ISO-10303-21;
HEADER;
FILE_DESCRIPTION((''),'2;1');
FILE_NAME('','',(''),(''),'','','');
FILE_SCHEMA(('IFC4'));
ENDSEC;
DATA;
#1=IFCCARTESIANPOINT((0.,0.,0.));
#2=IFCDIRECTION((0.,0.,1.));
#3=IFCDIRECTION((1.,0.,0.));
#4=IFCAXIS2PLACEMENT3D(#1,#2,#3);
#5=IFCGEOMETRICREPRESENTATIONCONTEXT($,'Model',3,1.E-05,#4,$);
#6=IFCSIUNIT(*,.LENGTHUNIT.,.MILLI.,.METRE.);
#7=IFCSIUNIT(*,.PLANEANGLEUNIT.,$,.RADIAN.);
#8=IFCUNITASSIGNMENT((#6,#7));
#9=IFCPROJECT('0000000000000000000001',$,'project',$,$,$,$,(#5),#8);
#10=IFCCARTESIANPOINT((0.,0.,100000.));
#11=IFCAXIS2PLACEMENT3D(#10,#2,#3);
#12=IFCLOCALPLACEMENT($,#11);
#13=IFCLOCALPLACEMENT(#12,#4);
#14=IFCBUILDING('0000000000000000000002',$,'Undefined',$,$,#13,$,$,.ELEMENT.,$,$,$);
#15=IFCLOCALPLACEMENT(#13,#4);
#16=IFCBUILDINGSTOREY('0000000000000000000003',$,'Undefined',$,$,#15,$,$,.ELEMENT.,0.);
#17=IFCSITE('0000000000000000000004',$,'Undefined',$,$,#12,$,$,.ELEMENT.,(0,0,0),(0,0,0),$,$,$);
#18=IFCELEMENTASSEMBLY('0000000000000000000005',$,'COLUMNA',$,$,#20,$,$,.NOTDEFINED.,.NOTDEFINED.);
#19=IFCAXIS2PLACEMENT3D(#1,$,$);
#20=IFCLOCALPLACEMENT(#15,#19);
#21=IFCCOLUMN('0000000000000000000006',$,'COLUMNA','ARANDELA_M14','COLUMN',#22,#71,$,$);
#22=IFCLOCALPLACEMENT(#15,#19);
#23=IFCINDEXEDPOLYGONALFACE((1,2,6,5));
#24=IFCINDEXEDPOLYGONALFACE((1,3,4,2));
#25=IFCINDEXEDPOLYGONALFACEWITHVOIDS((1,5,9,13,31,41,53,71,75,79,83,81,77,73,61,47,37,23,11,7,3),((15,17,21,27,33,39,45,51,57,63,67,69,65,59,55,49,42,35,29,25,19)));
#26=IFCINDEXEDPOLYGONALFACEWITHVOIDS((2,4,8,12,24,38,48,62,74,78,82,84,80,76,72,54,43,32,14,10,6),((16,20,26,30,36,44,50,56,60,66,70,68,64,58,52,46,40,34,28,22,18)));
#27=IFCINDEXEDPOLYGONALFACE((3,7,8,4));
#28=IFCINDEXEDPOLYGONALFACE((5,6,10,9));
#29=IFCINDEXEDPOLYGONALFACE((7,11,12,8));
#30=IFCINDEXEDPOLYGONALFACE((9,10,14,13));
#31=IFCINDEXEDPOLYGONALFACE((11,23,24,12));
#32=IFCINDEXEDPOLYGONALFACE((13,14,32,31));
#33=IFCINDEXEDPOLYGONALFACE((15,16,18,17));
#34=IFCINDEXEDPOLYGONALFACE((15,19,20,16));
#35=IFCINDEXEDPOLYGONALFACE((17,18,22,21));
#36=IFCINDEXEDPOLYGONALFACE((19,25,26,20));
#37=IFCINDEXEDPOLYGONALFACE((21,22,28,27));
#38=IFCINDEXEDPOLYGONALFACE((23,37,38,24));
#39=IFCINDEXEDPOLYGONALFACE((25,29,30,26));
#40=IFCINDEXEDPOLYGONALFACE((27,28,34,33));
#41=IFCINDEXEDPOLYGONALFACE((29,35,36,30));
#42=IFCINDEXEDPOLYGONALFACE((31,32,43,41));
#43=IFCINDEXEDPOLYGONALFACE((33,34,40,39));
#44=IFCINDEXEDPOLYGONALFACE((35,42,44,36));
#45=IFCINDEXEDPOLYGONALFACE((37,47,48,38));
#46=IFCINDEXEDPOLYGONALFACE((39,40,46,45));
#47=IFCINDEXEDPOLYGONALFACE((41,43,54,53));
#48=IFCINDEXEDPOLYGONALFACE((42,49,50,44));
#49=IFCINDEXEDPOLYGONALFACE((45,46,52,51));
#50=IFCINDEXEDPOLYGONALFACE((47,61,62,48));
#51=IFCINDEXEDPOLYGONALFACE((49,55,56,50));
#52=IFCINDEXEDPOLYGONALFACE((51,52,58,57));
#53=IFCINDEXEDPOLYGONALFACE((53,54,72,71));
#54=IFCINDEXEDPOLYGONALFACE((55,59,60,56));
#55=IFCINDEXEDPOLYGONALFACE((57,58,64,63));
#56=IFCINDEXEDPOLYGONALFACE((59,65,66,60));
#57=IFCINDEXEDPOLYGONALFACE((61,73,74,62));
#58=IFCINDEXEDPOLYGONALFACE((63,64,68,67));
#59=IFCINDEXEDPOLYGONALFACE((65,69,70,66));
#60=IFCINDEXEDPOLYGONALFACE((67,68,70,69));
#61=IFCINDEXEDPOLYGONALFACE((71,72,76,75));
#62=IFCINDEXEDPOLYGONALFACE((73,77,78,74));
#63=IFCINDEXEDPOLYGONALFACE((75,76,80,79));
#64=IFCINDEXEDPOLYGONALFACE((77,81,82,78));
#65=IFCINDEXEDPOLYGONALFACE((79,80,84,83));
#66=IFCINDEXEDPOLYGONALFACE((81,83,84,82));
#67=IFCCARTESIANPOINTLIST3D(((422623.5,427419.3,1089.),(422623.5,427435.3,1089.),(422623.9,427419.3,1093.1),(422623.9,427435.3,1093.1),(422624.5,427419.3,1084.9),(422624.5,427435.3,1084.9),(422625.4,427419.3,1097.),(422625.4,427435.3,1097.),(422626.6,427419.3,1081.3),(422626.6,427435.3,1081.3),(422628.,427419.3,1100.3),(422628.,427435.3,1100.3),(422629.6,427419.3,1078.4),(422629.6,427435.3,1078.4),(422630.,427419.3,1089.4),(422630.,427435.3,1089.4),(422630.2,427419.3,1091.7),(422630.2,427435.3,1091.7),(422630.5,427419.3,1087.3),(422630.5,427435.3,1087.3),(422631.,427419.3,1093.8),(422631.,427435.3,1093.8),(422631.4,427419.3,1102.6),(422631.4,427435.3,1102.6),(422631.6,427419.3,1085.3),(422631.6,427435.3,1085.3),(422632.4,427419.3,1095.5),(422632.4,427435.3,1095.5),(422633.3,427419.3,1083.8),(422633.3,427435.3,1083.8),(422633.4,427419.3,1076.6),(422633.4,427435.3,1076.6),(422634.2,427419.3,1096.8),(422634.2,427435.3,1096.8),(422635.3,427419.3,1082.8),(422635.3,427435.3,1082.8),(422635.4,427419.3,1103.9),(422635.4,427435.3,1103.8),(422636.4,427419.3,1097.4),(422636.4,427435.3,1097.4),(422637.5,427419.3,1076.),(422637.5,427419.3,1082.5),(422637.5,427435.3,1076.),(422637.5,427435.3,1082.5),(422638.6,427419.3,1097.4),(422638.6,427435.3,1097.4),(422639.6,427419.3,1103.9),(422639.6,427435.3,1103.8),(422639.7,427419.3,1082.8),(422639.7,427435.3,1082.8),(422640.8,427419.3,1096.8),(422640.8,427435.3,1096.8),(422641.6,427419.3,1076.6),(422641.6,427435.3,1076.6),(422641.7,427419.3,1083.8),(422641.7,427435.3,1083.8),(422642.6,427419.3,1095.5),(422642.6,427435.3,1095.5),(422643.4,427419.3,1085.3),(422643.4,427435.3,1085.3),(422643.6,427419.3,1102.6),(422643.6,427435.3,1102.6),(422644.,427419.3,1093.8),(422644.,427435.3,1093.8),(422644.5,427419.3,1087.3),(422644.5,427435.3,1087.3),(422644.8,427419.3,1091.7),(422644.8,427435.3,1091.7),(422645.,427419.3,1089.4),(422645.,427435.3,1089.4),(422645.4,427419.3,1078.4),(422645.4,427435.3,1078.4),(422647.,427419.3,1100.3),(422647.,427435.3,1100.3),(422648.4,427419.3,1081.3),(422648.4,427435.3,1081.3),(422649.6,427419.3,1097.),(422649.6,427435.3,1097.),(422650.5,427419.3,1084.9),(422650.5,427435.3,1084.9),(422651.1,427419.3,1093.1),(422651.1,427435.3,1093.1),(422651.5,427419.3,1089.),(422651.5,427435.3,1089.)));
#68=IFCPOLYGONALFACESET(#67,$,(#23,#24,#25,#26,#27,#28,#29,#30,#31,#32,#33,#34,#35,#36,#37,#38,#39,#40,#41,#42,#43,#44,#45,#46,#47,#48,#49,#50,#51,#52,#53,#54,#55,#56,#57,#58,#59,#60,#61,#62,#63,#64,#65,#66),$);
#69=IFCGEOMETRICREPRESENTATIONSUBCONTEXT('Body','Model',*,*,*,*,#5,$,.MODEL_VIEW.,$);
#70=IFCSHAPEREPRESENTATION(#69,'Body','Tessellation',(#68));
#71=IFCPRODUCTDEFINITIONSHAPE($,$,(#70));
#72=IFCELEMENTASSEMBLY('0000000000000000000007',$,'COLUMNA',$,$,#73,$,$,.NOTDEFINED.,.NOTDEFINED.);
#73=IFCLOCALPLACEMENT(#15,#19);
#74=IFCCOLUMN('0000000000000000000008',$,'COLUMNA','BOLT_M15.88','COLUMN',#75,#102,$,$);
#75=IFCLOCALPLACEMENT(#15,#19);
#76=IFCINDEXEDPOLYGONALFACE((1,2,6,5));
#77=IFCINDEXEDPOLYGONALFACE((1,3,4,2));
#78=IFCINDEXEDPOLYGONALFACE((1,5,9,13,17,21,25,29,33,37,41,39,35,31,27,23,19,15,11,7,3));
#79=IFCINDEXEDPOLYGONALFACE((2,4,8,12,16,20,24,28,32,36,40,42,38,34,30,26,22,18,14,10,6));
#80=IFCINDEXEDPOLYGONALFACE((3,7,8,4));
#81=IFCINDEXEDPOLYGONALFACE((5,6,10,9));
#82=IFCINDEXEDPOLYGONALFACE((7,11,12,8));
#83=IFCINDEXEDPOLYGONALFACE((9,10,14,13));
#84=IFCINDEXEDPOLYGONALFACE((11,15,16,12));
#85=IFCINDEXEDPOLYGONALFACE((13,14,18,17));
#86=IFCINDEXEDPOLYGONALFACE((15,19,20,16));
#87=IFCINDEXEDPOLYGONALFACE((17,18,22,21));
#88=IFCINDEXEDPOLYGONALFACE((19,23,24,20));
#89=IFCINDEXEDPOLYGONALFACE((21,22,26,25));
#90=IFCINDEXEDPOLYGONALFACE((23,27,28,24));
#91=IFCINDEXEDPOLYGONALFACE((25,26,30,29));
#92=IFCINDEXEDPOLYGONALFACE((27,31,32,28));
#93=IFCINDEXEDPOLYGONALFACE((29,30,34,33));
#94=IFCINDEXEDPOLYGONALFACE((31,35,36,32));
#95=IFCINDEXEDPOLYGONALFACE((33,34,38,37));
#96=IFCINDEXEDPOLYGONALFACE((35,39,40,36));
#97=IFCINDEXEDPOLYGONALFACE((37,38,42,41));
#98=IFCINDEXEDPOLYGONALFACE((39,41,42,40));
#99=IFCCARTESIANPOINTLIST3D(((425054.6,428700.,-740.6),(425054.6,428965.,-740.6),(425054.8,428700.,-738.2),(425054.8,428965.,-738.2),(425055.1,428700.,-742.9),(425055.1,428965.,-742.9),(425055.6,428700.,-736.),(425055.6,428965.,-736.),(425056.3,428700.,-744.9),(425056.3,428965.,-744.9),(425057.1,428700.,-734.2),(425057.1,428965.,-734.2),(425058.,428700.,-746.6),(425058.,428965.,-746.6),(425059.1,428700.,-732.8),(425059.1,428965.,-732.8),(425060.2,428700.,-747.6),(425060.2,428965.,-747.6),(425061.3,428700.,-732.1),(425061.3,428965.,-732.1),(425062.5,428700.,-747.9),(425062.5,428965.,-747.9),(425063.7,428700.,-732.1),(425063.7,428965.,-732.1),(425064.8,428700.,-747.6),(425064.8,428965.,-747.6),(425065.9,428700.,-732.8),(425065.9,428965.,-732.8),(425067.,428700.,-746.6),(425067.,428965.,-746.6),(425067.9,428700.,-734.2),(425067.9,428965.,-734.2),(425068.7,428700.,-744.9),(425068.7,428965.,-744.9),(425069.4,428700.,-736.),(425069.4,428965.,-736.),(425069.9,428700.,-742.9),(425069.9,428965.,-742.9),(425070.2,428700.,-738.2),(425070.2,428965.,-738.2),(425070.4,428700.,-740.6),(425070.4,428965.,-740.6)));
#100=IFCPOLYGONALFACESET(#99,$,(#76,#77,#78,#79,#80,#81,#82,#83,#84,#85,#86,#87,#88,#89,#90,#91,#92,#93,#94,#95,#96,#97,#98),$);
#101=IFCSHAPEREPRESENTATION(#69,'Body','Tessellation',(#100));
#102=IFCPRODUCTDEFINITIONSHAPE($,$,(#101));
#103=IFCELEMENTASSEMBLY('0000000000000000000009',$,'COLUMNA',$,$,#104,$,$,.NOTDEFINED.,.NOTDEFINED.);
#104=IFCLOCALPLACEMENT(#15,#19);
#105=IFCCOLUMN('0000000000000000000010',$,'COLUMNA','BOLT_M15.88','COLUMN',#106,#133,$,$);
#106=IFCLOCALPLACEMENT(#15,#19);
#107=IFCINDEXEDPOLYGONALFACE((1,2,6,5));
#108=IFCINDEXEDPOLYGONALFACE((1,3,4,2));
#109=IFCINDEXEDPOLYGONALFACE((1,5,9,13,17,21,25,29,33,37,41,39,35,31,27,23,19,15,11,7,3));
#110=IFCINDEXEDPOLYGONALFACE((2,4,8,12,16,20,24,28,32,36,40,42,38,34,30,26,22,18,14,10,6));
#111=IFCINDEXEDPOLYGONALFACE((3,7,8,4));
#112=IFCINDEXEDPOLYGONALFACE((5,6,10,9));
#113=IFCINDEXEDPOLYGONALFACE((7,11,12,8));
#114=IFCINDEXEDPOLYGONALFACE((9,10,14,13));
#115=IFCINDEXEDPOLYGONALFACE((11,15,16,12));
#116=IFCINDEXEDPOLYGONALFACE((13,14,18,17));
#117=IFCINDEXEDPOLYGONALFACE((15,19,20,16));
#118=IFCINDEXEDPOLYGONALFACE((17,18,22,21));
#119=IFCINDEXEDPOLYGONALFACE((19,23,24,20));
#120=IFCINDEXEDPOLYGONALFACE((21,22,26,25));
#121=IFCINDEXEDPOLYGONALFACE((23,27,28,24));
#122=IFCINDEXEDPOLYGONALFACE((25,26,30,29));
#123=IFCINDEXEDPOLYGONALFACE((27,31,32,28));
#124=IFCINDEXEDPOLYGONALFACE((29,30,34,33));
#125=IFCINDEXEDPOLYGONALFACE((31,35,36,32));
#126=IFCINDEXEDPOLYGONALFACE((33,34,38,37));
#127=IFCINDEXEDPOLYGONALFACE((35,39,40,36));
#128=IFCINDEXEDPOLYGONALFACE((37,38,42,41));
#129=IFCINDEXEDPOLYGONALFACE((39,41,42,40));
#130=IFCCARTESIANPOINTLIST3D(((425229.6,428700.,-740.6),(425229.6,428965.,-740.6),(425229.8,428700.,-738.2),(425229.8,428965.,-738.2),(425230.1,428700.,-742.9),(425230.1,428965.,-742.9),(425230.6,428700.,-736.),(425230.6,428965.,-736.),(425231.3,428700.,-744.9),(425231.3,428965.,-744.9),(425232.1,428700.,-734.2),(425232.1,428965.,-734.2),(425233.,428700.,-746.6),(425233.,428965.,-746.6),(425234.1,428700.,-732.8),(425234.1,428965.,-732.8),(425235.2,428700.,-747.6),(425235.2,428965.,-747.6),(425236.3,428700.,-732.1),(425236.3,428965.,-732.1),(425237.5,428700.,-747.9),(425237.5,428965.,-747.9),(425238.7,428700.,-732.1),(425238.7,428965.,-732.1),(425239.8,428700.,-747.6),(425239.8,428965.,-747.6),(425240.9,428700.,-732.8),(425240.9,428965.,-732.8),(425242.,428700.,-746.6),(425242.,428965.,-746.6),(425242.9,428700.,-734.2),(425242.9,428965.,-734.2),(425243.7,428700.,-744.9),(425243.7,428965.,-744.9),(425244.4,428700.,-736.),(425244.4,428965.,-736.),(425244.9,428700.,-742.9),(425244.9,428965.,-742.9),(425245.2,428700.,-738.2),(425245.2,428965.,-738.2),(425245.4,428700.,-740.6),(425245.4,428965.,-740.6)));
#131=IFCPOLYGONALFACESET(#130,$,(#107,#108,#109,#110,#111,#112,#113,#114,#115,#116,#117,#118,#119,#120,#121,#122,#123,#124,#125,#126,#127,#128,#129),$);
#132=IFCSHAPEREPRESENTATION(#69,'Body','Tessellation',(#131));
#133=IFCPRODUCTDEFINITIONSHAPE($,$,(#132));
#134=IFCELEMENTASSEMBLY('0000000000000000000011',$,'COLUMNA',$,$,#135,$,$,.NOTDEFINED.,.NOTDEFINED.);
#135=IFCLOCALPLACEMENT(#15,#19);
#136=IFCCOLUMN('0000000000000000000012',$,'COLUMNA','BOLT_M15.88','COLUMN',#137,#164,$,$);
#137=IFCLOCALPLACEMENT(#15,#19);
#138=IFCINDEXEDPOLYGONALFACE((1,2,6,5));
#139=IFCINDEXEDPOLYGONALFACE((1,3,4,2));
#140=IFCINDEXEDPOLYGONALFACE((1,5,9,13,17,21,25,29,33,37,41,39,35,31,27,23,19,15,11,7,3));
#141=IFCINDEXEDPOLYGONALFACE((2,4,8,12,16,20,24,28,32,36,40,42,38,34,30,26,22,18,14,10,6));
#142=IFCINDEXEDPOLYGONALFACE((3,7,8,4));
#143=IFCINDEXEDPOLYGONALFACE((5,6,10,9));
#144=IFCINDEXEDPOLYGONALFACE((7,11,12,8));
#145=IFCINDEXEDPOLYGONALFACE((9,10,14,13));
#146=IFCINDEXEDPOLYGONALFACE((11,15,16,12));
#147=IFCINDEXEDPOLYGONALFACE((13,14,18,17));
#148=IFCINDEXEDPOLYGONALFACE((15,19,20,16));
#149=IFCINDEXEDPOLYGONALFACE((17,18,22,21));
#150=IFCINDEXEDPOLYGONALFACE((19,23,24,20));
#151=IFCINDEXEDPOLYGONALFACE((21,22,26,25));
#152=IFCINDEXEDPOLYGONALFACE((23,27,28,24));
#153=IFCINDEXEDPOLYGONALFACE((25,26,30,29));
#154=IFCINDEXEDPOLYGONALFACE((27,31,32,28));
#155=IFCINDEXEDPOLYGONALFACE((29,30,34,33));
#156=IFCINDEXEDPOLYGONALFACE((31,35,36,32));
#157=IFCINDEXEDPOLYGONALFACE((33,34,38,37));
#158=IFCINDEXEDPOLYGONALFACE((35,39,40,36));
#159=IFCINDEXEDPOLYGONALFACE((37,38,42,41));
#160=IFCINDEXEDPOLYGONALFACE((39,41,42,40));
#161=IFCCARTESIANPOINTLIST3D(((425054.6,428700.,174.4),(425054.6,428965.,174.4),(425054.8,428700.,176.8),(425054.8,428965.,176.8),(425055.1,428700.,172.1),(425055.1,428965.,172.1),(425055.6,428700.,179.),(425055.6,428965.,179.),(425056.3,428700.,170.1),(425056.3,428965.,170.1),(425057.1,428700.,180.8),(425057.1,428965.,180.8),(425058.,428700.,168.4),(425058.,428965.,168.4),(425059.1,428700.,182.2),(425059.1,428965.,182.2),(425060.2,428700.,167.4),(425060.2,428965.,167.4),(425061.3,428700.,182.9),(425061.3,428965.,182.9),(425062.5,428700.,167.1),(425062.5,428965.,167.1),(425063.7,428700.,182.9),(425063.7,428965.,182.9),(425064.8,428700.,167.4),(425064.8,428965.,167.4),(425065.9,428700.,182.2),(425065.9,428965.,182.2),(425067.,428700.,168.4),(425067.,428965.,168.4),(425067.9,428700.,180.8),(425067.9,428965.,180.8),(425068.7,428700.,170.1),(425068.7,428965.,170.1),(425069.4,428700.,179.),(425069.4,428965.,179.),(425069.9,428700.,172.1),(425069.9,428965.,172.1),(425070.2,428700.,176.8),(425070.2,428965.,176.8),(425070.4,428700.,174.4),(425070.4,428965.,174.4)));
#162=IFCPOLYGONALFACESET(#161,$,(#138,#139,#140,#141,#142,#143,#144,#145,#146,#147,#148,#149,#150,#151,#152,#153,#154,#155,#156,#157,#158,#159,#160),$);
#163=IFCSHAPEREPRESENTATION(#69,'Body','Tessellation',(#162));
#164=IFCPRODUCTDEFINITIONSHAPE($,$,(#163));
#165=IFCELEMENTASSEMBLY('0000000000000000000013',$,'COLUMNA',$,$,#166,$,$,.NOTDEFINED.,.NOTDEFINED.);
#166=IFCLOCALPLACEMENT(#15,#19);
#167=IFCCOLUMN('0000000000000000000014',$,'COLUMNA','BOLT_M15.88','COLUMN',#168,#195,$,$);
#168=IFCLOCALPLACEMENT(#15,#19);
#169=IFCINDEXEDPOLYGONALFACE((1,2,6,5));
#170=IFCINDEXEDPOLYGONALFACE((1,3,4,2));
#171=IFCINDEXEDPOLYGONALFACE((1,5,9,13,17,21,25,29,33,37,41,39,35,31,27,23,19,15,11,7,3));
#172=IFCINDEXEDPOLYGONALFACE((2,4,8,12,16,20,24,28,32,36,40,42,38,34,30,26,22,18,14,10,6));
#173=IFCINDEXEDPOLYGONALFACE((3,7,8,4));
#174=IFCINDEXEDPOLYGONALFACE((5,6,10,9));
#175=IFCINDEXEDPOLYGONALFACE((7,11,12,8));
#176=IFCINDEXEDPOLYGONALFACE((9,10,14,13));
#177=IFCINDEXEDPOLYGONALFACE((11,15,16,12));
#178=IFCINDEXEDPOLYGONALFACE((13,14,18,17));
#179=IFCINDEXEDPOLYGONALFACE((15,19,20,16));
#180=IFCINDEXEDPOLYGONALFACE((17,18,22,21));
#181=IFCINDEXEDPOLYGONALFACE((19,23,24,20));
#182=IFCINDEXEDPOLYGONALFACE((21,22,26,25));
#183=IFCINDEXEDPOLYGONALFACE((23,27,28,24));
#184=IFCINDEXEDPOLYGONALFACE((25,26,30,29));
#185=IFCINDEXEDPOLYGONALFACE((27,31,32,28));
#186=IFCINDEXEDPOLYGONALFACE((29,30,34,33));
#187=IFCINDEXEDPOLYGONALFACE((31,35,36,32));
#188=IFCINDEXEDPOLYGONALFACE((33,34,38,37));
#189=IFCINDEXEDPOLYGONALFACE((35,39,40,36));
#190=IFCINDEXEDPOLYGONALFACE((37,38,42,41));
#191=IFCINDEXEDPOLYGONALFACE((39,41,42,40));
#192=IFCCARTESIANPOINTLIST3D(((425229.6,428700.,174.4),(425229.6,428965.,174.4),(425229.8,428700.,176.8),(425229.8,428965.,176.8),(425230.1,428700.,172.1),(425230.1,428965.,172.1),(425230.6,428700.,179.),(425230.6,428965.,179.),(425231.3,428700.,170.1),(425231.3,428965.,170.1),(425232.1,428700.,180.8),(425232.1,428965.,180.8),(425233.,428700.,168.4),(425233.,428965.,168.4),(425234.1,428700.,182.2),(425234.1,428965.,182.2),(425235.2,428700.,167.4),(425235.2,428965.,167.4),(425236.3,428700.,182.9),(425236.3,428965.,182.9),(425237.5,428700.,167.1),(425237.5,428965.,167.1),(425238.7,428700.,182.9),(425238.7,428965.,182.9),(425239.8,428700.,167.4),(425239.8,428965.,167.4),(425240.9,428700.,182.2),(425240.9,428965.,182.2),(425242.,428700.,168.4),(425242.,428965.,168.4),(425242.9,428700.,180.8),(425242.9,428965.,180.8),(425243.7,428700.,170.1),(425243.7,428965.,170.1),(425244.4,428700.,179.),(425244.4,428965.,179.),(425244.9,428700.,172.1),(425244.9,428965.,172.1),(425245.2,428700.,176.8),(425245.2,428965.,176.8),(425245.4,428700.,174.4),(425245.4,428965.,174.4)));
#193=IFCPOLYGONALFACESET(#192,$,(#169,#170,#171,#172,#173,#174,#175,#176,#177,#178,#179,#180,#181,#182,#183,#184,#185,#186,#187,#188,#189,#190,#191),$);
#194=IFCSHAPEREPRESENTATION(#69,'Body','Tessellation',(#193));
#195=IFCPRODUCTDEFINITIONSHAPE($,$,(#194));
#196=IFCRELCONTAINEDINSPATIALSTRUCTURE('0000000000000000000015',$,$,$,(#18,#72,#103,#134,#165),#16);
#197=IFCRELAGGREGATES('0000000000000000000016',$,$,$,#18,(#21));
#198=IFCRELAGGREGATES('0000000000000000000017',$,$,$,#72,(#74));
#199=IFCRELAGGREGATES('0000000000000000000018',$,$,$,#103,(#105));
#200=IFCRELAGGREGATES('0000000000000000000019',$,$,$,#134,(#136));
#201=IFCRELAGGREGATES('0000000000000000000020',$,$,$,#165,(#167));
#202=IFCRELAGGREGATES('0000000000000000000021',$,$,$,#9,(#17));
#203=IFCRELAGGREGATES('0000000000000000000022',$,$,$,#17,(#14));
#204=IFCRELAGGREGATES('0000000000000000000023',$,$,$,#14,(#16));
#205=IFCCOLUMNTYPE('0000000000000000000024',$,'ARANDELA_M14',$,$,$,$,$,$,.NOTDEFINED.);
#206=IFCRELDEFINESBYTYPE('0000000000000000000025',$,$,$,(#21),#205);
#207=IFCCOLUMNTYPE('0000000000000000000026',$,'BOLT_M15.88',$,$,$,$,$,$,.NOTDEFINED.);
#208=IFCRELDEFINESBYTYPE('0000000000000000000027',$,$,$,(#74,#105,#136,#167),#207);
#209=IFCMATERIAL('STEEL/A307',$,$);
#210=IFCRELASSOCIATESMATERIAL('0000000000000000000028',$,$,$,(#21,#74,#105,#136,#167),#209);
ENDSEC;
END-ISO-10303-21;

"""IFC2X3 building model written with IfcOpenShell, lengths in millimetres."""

from ifc_helpers import new_model, si_unit, frame, origin_with_axes, origin_2d_with_axis, place, context, subcontext, project, spatial, circle, hollow_circle, extrude, material, type_object, element, aggregate, save


model = new_model("IFC2X3")

# Units and contexts
model_context = context("Model", 3, precision=1e-05, world=origin_with_axes())
body_context = subcontext(model_context, "Body", "Model", "MODEL_VIEW")
ifc_project = project(units=[si_unit("LENGTHUNIT", "METRE", prefix="MILLI"), si_unit("PLANEANGLEUNIT", "RADIAN")], contexts=[model_context])

# Site, building, storey
site_placement = place(None, frame((0.0, 0.0, 100000.0), z_axis=(0.0, 0.0, 1.0), x_axis=(1.0, 0.0, 0.0)))
site = spatial("IfcSite", under=ifc_project, at=site_placement, Name="Undefined", CompositionType="ELEMENT", RefLatitude=(0, 0, 0), RefLongitude=(0, 0, 0))
building_placement = place(site_placement, origin_with_axes())
building = spatial("IfcBuilding", under=site, at=building_placement, Name="Undefined", CompositionType="ELEMENT")
storey_placement = place(building_placement, origin_with_axes())
storey = spatial("IfcBuildingStorey", under=building, at=storey_placement, Name="Undefined", CompositionType="ELEMENT", Elevation=0.0)

# Element assemblies, columns
ifc_material = material(Name="STEEL/A307")
column_type_1 = type_object("IfcColumnType", Name="ARANDELA_M14", PredefinedType="NOTDEFINED")
assembly_1_placement = place(storey_placement, origin_with_axes())
assembly_1 = element("IfcElementAssembly", 1, at=assembly_1_placement, inside=storey, Name="COLUMNA", AssemblyPlace="NOTDEFINED", PredefinedType="NOTDEFINED")
column_1_placement = place(assembly_1_placement, frame((422637.5, 427435.3, 1090.0), z_axis=(0.0, -1.0, 0.000285), x_axis=(-1.0, 0.0, 0.0)))
column_1 = element("IfcColumn", 2, at=column_1_placement, type_object=column_type_1, material=ifc_material, Name="COLUMNA", Description="ARANDELA_M14", ObjectType="COLUMN", context=body_context, shape_type="SweptSolid", body=[
    extrude(hollow_circle(Radius=14.0, WallThickness=6.5, at=origin_2d_with_axis()), frame((0.0, 0.0, 16.0), z_axis=(0.0, 0.0, -1.0), x_axis=(0.0, 1.0, 0.0)), (0.0, 0.0, 1.0), 16.0),
])
aggregate(assembly_1, [column_1])
assembly_2_placement = place(storey_placement, origin_with_axes())
assembly_2 = element("IfcElementAssembly", 3, at=assembly_2_placement, inside=storey, Name="COLUMNA", AssemblyPlace="NOTDEFINED", PredefinedType="NOTDEFINED")
column_type_2 = type_object("IfcColumnType", Name="BOLT_M15.88", PredefinedType="NOTDEFINED")
column_2_placement = place(assembly_2_placement, frame((425062.5, 428700.0, -740.0), z_axis=(0.0, 1.0, -0.000003), x_axis=(1.0, 0.0, 0.0)))
column_2 = element("IfcColumn", 4, at=column_2_placement, type_object=column_type_2, material=ifc_material, Name="COLUMNA", Description="BOLT_M15.88", ObjectType="COLUMN", context=body_context, shape_type="SweptSolid", body=[
    extrude(circle(Radius=7.9, at=origin_2d_with_axis()), frame((0.0, 0.0, 265.0), z_axis=(0.0, 0.0, -1.0), x_axis=(0.0, 1.0, 0.0)), (0.0, 0.0, 1.0), 265.0),
])
aggregate(assembly_2, [column_2])
assembly_3_placement = place(storey_placement, origin_with_axes())
assembly_3 = element("IfcElementAssembly", 5, at=assembly_3_placement, inside=storey, Name="COLUMNA", AssemblyPlace="NOTDEFINED", PredefinedType="NOTDEFINED")
column_3_placement = place(assembly_3_placement, frame((425237.5, 428700.0, -740.0), z_axis=(0.0, 1.0, -0.000003), x_axis=(1.0, 0.0, 0.0)))
column_3 = element("IfcColumn", 6, at=column_3_placement, type_object=column_type_2, material=ifc_material, Name="COLUMNA", Description="BOLT_M15.88", ObjectType="COLUMN", context=body_context, shape_type="SweptSolid", body=[
    extrude(circle(Radius=7.9, at=origin_2d_with_axis()), frame((0.0, 0.0, 265.0), z_axis=(0.0, 0.0, -1.0), x_axis=(0.0, 1.0, 0.0)), (0.0, 0.0, 1.0), 265.0),
])
aggregate(assembly_3, [column_3])
assembly_4_placement = place(storey_placement, origin_with_axes())
assembly_4 = element("IfcElementAssembly", 7, at=assembly_4_placement, inside=storey, Name="COLUMNA", AssemblyPlace="NOTDEFINED", PredefinedType="NOTDEFINED")
column_4_placement = place(assembly_4_placement, frame((425062.5, 428700.0, 175.0), z_axis=(0.0, 1.0, -0.000003), x_axis=(1.0, 0.0, 0.0)))
column_4 = element("IfcColumn", 8, at=column_4_placement, type_object=column_type_2, material=ifc_material, Name="COLUMNA", Description="BOLT_M15.88", ObjectType="COLUMN", context=body_context, shape_type="SweptSolid", body=[
    extrude(circle(Radius=7.9, at=origin_2d_with_axis()), frame((0.0, 0.0, 265.0), z_axis=(0.0, 0.0, -1.0), x_axis=(0.0, 1.0, 0.0)), (0.0, 0.0, 1.0), 265.0),
])
aggregate(assembly_4, [column_4])
assembly_5_placement = place(storey_placement, origin_with_axes())
assembly_5 = element("IfcElementAssembly", 9, at=assembly_5_placement, inside=storey, Name="COLUMNA", AssemblyPlace="NOTDEFINED", PredefinedType="NOTDEFINED")
column_5_placement = place(assembly_5_placement, frame((425237.5, 428700.0, 175.0), z_axis=(0.0, 1.0, -0.000003), x_axis=(1.0, 0.0, 0.0)))
column_5 = element("IfcColumn", 10, at=column_5_placement, type_object=column_type_2, material=ifc_material, Name="COLUMNA", Description="BOLT_M15.88", ObjectType="COLUMN", context=body_context, shape_type="SweptSolid", body=[
    extrude(circle(Radius=7.9, at=origin_2d_with_axis()), frame((0.0, 0.0, 265.0), z_axis=(0.0, 0.0, -1.0), x_axis=(0.0, 1.0, 0.0)), (0.0, 0.0, 1.0), 265.0),
])
aggregate(assembly_5, [column_5])

save(model, "model.ifc")
